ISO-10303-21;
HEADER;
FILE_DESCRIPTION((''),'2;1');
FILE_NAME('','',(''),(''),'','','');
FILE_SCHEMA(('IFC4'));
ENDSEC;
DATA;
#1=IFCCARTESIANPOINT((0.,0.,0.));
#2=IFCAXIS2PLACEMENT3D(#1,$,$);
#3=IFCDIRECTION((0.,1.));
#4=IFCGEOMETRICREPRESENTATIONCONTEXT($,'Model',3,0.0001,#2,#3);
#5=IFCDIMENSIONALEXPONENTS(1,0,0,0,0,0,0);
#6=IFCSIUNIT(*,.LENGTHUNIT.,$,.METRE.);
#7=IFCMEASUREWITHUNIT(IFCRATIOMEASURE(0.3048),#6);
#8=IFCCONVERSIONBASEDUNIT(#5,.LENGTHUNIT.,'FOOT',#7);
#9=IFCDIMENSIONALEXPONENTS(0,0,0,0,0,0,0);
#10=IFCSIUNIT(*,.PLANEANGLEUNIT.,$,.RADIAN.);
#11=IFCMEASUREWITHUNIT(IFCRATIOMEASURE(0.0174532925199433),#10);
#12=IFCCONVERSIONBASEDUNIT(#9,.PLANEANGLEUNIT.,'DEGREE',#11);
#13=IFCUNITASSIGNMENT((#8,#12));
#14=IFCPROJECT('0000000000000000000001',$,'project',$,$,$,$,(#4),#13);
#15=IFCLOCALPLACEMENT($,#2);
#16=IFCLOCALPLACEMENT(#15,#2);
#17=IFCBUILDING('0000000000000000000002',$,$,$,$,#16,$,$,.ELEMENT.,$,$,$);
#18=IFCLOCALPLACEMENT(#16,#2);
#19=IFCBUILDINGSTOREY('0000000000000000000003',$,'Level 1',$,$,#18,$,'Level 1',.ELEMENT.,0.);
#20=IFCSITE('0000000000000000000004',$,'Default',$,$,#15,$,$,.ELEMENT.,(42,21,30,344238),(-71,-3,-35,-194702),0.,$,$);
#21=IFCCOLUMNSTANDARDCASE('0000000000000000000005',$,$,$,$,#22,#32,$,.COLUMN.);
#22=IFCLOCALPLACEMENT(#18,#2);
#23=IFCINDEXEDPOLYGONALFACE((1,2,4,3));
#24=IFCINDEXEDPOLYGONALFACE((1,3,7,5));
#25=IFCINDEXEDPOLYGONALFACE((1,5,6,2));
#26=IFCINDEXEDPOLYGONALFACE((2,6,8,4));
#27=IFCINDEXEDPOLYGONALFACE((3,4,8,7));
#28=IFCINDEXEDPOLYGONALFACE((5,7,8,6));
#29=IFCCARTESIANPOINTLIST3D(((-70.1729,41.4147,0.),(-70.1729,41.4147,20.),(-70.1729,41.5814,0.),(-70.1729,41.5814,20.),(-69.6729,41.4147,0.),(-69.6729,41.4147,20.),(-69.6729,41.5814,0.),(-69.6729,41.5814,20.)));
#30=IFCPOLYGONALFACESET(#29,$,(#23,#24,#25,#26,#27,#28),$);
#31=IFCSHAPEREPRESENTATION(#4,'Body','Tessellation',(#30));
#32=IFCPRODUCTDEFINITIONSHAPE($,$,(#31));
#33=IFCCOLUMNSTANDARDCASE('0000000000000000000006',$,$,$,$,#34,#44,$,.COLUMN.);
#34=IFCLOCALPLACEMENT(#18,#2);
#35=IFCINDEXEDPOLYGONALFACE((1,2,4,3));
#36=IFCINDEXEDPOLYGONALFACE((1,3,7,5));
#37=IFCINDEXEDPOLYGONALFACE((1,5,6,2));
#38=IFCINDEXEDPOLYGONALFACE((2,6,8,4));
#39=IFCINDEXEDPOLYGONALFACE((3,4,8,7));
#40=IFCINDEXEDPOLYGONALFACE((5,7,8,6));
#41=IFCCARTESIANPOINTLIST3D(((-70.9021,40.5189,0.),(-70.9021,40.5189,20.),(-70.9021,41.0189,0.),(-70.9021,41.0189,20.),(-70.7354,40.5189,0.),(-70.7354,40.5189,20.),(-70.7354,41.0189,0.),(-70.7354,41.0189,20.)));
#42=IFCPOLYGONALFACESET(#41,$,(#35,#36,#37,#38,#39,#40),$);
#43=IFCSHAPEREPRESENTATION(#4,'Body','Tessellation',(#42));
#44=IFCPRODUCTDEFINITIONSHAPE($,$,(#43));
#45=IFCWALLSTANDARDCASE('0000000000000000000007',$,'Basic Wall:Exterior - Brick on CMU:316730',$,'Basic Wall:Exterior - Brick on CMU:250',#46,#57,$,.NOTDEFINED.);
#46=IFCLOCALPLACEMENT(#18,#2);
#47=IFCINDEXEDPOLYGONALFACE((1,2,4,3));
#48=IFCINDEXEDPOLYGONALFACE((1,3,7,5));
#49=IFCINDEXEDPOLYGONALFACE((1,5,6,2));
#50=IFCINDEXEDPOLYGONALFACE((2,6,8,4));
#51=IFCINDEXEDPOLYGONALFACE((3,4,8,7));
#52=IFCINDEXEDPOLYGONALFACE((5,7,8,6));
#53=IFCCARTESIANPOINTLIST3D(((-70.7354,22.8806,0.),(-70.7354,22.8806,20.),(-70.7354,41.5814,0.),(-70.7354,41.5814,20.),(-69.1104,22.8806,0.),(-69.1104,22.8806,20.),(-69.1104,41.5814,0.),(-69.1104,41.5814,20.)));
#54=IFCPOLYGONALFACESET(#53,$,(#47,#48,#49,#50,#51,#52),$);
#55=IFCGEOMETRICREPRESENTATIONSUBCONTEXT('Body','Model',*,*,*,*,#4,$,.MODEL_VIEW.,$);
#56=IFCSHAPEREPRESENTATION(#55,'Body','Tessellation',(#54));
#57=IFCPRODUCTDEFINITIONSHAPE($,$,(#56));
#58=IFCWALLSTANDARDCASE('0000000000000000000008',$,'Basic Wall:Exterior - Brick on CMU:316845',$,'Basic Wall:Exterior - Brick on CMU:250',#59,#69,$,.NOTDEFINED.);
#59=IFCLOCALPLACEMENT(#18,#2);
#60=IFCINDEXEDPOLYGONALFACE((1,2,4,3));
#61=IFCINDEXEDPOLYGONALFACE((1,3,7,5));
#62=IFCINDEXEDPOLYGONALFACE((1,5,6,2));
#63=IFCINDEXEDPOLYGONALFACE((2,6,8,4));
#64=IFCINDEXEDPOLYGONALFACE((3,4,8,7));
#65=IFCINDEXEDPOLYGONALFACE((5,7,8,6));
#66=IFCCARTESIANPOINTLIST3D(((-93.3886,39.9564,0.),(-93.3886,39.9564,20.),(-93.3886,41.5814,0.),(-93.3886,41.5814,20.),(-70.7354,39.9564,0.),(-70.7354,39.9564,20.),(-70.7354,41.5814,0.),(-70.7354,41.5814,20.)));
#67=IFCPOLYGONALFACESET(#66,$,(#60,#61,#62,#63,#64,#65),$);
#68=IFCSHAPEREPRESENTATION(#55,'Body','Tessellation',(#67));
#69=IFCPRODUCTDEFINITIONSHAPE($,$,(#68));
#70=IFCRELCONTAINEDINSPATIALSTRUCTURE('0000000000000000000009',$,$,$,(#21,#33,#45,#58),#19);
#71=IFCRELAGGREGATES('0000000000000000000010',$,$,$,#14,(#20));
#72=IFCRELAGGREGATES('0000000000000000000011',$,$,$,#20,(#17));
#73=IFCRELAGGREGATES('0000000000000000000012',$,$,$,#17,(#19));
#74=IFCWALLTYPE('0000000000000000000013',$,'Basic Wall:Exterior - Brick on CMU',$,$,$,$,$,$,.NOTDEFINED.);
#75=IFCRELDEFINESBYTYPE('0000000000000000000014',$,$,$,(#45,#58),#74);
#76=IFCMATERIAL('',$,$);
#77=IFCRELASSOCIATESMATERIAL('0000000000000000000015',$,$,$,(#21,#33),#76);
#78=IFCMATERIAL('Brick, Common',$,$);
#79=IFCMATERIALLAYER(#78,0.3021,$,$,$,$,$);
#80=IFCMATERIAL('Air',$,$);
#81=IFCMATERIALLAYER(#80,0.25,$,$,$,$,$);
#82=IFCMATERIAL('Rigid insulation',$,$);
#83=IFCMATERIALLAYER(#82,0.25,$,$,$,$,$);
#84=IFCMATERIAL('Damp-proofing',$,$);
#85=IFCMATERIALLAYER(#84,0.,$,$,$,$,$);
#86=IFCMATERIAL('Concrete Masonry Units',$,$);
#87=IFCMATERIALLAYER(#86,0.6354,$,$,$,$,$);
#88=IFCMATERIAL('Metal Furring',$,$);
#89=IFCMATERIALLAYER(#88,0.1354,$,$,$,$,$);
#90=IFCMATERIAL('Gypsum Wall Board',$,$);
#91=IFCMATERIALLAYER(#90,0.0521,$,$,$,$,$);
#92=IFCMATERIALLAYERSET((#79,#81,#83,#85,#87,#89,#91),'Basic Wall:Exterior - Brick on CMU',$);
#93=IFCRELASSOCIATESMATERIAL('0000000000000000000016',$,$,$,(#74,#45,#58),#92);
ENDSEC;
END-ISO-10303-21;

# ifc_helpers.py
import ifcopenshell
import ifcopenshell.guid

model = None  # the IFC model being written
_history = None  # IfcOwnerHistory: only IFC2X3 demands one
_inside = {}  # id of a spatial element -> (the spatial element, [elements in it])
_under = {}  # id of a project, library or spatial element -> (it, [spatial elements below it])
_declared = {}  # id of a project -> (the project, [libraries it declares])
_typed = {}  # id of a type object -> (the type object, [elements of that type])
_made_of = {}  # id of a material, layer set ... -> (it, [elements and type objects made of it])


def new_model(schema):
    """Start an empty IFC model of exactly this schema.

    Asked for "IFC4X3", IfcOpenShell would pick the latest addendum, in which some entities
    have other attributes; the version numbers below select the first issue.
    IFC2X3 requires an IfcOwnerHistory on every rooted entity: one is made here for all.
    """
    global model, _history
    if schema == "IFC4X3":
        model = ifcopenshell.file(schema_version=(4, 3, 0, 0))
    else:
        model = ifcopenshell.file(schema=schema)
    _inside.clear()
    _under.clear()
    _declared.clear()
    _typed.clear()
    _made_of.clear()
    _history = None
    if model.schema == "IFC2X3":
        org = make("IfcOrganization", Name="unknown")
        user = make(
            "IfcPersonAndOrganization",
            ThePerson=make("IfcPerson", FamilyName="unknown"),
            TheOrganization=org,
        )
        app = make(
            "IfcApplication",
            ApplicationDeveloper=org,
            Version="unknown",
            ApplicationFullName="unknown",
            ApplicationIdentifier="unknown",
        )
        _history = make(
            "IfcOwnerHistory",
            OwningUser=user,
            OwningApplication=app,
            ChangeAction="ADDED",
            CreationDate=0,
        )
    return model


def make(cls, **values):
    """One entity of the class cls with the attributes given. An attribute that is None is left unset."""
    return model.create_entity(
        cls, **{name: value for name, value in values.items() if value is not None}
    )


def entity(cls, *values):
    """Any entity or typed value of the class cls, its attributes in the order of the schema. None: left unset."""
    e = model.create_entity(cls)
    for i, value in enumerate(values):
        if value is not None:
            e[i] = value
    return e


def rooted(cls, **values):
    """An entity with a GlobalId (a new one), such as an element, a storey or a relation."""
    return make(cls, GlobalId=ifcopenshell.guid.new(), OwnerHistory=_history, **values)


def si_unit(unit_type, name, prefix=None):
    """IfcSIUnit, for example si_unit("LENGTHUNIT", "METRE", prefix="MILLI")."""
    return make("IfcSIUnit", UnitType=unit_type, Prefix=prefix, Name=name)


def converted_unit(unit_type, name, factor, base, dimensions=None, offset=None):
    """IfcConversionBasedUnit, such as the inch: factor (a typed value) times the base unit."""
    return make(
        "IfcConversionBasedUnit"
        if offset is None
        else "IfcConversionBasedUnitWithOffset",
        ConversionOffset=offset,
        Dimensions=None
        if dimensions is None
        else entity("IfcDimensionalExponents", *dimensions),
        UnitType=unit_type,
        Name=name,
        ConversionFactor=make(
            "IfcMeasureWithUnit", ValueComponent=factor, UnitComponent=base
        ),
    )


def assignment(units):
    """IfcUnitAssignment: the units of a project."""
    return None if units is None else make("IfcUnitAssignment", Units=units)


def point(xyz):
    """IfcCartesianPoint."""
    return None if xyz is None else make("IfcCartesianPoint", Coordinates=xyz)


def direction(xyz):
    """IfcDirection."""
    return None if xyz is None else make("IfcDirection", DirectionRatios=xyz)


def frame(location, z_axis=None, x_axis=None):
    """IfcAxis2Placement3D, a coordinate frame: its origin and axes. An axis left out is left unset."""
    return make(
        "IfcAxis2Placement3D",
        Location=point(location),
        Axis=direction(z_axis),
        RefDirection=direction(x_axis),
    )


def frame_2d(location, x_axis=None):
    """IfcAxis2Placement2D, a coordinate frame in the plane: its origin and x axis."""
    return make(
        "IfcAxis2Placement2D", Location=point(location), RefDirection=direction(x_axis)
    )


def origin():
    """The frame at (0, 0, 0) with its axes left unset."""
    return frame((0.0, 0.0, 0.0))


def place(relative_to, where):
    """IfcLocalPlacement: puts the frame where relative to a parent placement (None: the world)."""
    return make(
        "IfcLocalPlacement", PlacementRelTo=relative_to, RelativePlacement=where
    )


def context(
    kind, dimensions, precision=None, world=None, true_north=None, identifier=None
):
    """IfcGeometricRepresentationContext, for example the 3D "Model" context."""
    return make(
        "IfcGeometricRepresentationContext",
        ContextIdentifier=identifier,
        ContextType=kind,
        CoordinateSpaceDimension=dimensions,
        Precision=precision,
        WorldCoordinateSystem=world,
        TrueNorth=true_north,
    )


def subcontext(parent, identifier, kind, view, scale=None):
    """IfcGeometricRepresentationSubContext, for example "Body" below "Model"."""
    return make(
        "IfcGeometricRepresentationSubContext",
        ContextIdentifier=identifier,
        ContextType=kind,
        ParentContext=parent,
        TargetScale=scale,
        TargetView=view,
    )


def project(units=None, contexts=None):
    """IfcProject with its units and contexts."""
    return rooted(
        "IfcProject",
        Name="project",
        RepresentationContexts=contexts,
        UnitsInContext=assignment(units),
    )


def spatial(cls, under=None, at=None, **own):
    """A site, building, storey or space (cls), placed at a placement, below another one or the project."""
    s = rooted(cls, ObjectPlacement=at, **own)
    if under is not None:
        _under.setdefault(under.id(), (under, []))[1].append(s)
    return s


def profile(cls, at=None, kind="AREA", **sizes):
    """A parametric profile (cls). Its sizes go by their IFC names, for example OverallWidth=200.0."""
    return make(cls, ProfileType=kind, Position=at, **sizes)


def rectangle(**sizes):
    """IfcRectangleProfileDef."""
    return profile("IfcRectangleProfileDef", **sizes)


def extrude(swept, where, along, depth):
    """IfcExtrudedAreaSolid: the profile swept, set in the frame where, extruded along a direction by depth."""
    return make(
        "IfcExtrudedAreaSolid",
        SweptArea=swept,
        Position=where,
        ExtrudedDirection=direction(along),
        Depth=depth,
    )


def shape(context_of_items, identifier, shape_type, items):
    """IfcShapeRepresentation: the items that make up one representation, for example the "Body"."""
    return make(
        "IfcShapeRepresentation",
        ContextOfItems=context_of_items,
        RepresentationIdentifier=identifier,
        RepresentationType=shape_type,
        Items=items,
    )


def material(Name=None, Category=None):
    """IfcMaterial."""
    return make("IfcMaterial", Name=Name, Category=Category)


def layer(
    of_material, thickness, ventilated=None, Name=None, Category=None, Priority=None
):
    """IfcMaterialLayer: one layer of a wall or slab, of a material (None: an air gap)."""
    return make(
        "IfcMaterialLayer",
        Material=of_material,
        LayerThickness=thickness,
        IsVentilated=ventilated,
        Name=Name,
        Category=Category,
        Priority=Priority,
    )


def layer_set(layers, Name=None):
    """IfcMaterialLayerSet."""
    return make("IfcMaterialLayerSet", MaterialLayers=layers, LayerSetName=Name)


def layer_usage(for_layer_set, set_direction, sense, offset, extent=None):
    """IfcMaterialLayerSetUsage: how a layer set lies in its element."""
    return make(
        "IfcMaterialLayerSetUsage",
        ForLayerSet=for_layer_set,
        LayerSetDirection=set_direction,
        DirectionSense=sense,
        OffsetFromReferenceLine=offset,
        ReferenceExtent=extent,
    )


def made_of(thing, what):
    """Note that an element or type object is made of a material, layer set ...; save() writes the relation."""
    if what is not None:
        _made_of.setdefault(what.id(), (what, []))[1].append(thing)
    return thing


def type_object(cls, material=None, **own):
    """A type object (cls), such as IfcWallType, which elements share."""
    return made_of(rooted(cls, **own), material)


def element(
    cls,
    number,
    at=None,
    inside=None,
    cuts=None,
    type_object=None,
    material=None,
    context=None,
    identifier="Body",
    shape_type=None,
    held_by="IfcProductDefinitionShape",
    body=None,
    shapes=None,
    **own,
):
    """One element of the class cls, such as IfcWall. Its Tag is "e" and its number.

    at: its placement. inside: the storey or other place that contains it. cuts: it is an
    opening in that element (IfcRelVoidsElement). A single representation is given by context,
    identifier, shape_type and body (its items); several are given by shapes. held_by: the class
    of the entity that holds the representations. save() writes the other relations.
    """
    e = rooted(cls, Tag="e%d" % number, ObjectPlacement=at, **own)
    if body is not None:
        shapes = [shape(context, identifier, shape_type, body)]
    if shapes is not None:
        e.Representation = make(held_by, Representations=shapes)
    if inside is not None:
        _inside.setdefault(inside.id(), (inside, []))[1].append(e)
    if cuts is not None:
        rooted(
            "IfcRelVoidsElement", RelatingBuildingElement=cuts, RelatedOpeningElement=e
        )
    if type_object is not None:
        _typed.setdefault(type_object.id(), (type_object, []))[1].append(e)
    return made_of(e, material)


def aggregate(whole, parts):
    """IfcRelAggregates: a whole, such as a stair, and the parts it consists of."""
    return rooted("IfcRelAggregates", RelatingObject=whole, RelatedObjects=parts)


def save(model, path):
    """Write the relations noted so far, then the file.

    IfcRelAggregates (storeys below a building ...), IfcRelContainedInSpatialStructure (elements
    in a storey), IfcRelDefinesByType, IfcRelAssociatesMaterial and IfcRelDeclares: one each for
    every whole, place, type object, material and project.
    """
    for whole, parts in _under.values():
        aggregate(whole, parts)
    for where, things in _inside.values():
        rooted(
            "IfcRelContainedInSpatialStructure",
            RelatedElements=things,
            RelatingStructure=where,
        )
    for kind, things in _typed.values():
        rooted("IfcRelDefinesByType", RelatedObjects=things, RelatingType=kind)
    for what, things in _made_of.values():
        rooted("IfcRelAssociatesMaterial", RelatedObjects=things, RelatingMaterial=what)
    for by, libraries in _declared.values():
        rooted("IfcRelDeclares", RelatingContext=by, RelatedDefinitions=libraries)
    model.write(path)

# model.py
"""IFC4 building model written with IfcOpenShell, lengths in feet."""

from ifc_helpers import new_model, entity, si_unit, converted_unit, direction, frame, frame_2d, origin, place, context, subcontext, project, spatial, rectangle, extrude, material, layer, layer_set, layer_usage, type_object, element, save


model = new_model("IFC4")

# Units and contexts
model_context = context("Model", 3, precision=0.0001, world=origin(), true_north=direction((0.0, 1.0)))
body_context = subcontext(model_context, "Body", "Model", "MODEL_VIEW")
ifc_project = project(units=[converted_unit("LENGTHUNIT", "FOOT", entity("IfcRatioMeasure", 0.3048), si_unit("LENGTHUNIT", "METRE"), dimensions=[1, 0, 0, 0, 0, 0, 0]), converted_unit("PLANEANGLEUNIT", "DEGREE", entity("IfcRatioMeasure", 0.0174532925199433), si_unit("PLANEANGLEUNIT", "RADIAN"), dimensions=[0, 0, 0, 0, 0, 0, 0])], contexts=[model_context])

# Site, building, storey
site_placement = place(None, origin())
site = spatial("IfcSite", under=ifc_project, at=site_placement, Name="Default", CompositionType="ELEMENT", RefLatitude=(42, 21, 30, 344238), RefLongitude=(-71, -3, -35, -194702), RefElevation=0.0)
building_placement = place(site_placement, origin())
building = spatial("IfcBuilding", under=site, at=building_placement, CompositionType="ELEMENT")
storey_placement = place(building_placement, origin())
storey = spatial("IfcBuildingStorey", under=building, at=storey_placement, Name="Level 1", LongName="Level 1", CompositionType="ELEMENT", Elevation=0.0)

# Columns
ifc_material_1 = material(Name="")
wall_1_placement = place(storey_placement, frame((-69.9229, 41.5814, 0.0), z_axis=(0.0, 0.0, 1.0), x_axis=(0.0, -1.0, 0.0)))
for number, where, z_axis, x_axis in (
    (1, (0.0833, 0.0, 0.0), (0.0, 0.0, 1.0), (1.0, 0.0, 0.0)),
):
    element("IfcColumnStandardCase", number, at=place(wall_1_placement, frame(where, z_axis=z_axis, x_axis=x_axis)), inside=storey, material=ifc_material_1, PredefinedType="COLUMN", context=model_context, shape_type="SweptSolid", body=[
        extrude(rectangle(XDim=0.1667, YDim=0.5), origin(), (0.0, 0.0, 1.0), 20.0),
    ])
wall_2_placement = place(storey_placement, frame((-70.7354, 40.7689, 0.0), z_axis=(0.0, 0.0, 1.0), x_axis=(-1.0, 0.0, 0.0)))
for number, where, z_axis, x_axis in (
    (2, (0.0833, 0.0, 0.0), (0.0, 0.0, 1.0), (1.0, 0.0, 0.0)),
):
    element("IfcColumnStandardCase", number, at=place(wall_2_placement, frame(where, z_axis=z_axis, x_axis=x_axis)), inside=storey, material=ifc_material_1, PredefinedType="COLUMN", context=model_context, shape_type="SweptSolid", body=[
        extrude(rectangle(XDim=0.1667, YDim=0.5), origin(), (0.0, 0.0, 1.0), 20.0),
    ])

# Walls
ifc_material_2 = material(Name="Brick, Common")
ifc_layer_1 = layer(ifc_material_2, 0.3021)
ifc_material_3 = material(Name="Air")
ifc_layer_2 = layer(ifc_material_3, 0.25)
ifc_material_4 = material(Name="Rigid insulation")
ifc_layer_3 = layer(ifc_material_4, 0.25)
ifc_material_5 = material(Name="Damp-proofing")
ifc_layer_4 = layer(ifc_material_5, 0.0)
ifc_material_6 = material(Name="Concrete Masonry Units")
ifc_layer_5 = layer(ifc_material_6, 0.6354)
ifc_material_7 = material(Name="Metal Furring")
ifc_layer_6 = layer(ifc_material_7, 0.1354)
ifc_material_8 = material(Name="Gypsum Wall Board")
ifc_layer_7 = layer(ifc_material_8, 0.0521)
ifc_layer_set = layer_set([ifc_layer_1, ifc_layer_2, ifc_layer_3, ifc_layer_4, ifc_layer_5, ifc_layer_6, ifc_layer_7], Name="Basic Wall:Exterior - Brick on CMU")
ifc_layer_usage_1 = layer_usage(ifc_layer_set, "AXIS2", "NEGATIVE", 0.8125)
wall_type = type_object("IfcWallType", Name="Basic Wall:Exterior - Brick on CMU", PredefinedType="NOTDEFINED", material=ifc_layer_set)
element("IfcWallStandardCase", 3, at=wall_1_placement, inside=storey, type_object=wall_type, material=ifc_layer_usage_1, Name="Basic Wall:Exterior - Brick on CMU:316730", ObjectType="Basic Wall:Exterior - Brick on CMU:250", PredefinedType="NOTDEFINED", context=body_context, shape_type="SweptSolid", body=[
    extrude(rectangle(XDim=18.7008, YDim=1.625, at=frame_2d((9.3504, 0.0), x_axis=(-1.0, 0.0))), origin(), (0.0, 0.0, 1.0), 20.0),
])
ifc_layer_usage_2 = layer_usage(ifc_layer_set, "AXIS2", "NEGATIVE", 0.8125)
element("IfcWallStandardCase", 4, at=wall_2_placement, inside=storey, type_object=wall_type, material=ifc_layer_usage_2, Name="Basic Wall:Exterior - Brick on CMU:316845", ObjectType="Basic Wall:Exterior - Brick on CMU:250", PredefinedType="NOTDEFINED", context=body_context, shape_type="SweptSolid", body=[
    extrude(rectangle(XDim=22.6532, YDim=1.625, at=frame_2d((11.3266, 0.0), x_axis=(-1.0, 0.0))), origin(), (0.0, 0.0, 1.0), 20.0),
])

save(model, "model.ifc")
